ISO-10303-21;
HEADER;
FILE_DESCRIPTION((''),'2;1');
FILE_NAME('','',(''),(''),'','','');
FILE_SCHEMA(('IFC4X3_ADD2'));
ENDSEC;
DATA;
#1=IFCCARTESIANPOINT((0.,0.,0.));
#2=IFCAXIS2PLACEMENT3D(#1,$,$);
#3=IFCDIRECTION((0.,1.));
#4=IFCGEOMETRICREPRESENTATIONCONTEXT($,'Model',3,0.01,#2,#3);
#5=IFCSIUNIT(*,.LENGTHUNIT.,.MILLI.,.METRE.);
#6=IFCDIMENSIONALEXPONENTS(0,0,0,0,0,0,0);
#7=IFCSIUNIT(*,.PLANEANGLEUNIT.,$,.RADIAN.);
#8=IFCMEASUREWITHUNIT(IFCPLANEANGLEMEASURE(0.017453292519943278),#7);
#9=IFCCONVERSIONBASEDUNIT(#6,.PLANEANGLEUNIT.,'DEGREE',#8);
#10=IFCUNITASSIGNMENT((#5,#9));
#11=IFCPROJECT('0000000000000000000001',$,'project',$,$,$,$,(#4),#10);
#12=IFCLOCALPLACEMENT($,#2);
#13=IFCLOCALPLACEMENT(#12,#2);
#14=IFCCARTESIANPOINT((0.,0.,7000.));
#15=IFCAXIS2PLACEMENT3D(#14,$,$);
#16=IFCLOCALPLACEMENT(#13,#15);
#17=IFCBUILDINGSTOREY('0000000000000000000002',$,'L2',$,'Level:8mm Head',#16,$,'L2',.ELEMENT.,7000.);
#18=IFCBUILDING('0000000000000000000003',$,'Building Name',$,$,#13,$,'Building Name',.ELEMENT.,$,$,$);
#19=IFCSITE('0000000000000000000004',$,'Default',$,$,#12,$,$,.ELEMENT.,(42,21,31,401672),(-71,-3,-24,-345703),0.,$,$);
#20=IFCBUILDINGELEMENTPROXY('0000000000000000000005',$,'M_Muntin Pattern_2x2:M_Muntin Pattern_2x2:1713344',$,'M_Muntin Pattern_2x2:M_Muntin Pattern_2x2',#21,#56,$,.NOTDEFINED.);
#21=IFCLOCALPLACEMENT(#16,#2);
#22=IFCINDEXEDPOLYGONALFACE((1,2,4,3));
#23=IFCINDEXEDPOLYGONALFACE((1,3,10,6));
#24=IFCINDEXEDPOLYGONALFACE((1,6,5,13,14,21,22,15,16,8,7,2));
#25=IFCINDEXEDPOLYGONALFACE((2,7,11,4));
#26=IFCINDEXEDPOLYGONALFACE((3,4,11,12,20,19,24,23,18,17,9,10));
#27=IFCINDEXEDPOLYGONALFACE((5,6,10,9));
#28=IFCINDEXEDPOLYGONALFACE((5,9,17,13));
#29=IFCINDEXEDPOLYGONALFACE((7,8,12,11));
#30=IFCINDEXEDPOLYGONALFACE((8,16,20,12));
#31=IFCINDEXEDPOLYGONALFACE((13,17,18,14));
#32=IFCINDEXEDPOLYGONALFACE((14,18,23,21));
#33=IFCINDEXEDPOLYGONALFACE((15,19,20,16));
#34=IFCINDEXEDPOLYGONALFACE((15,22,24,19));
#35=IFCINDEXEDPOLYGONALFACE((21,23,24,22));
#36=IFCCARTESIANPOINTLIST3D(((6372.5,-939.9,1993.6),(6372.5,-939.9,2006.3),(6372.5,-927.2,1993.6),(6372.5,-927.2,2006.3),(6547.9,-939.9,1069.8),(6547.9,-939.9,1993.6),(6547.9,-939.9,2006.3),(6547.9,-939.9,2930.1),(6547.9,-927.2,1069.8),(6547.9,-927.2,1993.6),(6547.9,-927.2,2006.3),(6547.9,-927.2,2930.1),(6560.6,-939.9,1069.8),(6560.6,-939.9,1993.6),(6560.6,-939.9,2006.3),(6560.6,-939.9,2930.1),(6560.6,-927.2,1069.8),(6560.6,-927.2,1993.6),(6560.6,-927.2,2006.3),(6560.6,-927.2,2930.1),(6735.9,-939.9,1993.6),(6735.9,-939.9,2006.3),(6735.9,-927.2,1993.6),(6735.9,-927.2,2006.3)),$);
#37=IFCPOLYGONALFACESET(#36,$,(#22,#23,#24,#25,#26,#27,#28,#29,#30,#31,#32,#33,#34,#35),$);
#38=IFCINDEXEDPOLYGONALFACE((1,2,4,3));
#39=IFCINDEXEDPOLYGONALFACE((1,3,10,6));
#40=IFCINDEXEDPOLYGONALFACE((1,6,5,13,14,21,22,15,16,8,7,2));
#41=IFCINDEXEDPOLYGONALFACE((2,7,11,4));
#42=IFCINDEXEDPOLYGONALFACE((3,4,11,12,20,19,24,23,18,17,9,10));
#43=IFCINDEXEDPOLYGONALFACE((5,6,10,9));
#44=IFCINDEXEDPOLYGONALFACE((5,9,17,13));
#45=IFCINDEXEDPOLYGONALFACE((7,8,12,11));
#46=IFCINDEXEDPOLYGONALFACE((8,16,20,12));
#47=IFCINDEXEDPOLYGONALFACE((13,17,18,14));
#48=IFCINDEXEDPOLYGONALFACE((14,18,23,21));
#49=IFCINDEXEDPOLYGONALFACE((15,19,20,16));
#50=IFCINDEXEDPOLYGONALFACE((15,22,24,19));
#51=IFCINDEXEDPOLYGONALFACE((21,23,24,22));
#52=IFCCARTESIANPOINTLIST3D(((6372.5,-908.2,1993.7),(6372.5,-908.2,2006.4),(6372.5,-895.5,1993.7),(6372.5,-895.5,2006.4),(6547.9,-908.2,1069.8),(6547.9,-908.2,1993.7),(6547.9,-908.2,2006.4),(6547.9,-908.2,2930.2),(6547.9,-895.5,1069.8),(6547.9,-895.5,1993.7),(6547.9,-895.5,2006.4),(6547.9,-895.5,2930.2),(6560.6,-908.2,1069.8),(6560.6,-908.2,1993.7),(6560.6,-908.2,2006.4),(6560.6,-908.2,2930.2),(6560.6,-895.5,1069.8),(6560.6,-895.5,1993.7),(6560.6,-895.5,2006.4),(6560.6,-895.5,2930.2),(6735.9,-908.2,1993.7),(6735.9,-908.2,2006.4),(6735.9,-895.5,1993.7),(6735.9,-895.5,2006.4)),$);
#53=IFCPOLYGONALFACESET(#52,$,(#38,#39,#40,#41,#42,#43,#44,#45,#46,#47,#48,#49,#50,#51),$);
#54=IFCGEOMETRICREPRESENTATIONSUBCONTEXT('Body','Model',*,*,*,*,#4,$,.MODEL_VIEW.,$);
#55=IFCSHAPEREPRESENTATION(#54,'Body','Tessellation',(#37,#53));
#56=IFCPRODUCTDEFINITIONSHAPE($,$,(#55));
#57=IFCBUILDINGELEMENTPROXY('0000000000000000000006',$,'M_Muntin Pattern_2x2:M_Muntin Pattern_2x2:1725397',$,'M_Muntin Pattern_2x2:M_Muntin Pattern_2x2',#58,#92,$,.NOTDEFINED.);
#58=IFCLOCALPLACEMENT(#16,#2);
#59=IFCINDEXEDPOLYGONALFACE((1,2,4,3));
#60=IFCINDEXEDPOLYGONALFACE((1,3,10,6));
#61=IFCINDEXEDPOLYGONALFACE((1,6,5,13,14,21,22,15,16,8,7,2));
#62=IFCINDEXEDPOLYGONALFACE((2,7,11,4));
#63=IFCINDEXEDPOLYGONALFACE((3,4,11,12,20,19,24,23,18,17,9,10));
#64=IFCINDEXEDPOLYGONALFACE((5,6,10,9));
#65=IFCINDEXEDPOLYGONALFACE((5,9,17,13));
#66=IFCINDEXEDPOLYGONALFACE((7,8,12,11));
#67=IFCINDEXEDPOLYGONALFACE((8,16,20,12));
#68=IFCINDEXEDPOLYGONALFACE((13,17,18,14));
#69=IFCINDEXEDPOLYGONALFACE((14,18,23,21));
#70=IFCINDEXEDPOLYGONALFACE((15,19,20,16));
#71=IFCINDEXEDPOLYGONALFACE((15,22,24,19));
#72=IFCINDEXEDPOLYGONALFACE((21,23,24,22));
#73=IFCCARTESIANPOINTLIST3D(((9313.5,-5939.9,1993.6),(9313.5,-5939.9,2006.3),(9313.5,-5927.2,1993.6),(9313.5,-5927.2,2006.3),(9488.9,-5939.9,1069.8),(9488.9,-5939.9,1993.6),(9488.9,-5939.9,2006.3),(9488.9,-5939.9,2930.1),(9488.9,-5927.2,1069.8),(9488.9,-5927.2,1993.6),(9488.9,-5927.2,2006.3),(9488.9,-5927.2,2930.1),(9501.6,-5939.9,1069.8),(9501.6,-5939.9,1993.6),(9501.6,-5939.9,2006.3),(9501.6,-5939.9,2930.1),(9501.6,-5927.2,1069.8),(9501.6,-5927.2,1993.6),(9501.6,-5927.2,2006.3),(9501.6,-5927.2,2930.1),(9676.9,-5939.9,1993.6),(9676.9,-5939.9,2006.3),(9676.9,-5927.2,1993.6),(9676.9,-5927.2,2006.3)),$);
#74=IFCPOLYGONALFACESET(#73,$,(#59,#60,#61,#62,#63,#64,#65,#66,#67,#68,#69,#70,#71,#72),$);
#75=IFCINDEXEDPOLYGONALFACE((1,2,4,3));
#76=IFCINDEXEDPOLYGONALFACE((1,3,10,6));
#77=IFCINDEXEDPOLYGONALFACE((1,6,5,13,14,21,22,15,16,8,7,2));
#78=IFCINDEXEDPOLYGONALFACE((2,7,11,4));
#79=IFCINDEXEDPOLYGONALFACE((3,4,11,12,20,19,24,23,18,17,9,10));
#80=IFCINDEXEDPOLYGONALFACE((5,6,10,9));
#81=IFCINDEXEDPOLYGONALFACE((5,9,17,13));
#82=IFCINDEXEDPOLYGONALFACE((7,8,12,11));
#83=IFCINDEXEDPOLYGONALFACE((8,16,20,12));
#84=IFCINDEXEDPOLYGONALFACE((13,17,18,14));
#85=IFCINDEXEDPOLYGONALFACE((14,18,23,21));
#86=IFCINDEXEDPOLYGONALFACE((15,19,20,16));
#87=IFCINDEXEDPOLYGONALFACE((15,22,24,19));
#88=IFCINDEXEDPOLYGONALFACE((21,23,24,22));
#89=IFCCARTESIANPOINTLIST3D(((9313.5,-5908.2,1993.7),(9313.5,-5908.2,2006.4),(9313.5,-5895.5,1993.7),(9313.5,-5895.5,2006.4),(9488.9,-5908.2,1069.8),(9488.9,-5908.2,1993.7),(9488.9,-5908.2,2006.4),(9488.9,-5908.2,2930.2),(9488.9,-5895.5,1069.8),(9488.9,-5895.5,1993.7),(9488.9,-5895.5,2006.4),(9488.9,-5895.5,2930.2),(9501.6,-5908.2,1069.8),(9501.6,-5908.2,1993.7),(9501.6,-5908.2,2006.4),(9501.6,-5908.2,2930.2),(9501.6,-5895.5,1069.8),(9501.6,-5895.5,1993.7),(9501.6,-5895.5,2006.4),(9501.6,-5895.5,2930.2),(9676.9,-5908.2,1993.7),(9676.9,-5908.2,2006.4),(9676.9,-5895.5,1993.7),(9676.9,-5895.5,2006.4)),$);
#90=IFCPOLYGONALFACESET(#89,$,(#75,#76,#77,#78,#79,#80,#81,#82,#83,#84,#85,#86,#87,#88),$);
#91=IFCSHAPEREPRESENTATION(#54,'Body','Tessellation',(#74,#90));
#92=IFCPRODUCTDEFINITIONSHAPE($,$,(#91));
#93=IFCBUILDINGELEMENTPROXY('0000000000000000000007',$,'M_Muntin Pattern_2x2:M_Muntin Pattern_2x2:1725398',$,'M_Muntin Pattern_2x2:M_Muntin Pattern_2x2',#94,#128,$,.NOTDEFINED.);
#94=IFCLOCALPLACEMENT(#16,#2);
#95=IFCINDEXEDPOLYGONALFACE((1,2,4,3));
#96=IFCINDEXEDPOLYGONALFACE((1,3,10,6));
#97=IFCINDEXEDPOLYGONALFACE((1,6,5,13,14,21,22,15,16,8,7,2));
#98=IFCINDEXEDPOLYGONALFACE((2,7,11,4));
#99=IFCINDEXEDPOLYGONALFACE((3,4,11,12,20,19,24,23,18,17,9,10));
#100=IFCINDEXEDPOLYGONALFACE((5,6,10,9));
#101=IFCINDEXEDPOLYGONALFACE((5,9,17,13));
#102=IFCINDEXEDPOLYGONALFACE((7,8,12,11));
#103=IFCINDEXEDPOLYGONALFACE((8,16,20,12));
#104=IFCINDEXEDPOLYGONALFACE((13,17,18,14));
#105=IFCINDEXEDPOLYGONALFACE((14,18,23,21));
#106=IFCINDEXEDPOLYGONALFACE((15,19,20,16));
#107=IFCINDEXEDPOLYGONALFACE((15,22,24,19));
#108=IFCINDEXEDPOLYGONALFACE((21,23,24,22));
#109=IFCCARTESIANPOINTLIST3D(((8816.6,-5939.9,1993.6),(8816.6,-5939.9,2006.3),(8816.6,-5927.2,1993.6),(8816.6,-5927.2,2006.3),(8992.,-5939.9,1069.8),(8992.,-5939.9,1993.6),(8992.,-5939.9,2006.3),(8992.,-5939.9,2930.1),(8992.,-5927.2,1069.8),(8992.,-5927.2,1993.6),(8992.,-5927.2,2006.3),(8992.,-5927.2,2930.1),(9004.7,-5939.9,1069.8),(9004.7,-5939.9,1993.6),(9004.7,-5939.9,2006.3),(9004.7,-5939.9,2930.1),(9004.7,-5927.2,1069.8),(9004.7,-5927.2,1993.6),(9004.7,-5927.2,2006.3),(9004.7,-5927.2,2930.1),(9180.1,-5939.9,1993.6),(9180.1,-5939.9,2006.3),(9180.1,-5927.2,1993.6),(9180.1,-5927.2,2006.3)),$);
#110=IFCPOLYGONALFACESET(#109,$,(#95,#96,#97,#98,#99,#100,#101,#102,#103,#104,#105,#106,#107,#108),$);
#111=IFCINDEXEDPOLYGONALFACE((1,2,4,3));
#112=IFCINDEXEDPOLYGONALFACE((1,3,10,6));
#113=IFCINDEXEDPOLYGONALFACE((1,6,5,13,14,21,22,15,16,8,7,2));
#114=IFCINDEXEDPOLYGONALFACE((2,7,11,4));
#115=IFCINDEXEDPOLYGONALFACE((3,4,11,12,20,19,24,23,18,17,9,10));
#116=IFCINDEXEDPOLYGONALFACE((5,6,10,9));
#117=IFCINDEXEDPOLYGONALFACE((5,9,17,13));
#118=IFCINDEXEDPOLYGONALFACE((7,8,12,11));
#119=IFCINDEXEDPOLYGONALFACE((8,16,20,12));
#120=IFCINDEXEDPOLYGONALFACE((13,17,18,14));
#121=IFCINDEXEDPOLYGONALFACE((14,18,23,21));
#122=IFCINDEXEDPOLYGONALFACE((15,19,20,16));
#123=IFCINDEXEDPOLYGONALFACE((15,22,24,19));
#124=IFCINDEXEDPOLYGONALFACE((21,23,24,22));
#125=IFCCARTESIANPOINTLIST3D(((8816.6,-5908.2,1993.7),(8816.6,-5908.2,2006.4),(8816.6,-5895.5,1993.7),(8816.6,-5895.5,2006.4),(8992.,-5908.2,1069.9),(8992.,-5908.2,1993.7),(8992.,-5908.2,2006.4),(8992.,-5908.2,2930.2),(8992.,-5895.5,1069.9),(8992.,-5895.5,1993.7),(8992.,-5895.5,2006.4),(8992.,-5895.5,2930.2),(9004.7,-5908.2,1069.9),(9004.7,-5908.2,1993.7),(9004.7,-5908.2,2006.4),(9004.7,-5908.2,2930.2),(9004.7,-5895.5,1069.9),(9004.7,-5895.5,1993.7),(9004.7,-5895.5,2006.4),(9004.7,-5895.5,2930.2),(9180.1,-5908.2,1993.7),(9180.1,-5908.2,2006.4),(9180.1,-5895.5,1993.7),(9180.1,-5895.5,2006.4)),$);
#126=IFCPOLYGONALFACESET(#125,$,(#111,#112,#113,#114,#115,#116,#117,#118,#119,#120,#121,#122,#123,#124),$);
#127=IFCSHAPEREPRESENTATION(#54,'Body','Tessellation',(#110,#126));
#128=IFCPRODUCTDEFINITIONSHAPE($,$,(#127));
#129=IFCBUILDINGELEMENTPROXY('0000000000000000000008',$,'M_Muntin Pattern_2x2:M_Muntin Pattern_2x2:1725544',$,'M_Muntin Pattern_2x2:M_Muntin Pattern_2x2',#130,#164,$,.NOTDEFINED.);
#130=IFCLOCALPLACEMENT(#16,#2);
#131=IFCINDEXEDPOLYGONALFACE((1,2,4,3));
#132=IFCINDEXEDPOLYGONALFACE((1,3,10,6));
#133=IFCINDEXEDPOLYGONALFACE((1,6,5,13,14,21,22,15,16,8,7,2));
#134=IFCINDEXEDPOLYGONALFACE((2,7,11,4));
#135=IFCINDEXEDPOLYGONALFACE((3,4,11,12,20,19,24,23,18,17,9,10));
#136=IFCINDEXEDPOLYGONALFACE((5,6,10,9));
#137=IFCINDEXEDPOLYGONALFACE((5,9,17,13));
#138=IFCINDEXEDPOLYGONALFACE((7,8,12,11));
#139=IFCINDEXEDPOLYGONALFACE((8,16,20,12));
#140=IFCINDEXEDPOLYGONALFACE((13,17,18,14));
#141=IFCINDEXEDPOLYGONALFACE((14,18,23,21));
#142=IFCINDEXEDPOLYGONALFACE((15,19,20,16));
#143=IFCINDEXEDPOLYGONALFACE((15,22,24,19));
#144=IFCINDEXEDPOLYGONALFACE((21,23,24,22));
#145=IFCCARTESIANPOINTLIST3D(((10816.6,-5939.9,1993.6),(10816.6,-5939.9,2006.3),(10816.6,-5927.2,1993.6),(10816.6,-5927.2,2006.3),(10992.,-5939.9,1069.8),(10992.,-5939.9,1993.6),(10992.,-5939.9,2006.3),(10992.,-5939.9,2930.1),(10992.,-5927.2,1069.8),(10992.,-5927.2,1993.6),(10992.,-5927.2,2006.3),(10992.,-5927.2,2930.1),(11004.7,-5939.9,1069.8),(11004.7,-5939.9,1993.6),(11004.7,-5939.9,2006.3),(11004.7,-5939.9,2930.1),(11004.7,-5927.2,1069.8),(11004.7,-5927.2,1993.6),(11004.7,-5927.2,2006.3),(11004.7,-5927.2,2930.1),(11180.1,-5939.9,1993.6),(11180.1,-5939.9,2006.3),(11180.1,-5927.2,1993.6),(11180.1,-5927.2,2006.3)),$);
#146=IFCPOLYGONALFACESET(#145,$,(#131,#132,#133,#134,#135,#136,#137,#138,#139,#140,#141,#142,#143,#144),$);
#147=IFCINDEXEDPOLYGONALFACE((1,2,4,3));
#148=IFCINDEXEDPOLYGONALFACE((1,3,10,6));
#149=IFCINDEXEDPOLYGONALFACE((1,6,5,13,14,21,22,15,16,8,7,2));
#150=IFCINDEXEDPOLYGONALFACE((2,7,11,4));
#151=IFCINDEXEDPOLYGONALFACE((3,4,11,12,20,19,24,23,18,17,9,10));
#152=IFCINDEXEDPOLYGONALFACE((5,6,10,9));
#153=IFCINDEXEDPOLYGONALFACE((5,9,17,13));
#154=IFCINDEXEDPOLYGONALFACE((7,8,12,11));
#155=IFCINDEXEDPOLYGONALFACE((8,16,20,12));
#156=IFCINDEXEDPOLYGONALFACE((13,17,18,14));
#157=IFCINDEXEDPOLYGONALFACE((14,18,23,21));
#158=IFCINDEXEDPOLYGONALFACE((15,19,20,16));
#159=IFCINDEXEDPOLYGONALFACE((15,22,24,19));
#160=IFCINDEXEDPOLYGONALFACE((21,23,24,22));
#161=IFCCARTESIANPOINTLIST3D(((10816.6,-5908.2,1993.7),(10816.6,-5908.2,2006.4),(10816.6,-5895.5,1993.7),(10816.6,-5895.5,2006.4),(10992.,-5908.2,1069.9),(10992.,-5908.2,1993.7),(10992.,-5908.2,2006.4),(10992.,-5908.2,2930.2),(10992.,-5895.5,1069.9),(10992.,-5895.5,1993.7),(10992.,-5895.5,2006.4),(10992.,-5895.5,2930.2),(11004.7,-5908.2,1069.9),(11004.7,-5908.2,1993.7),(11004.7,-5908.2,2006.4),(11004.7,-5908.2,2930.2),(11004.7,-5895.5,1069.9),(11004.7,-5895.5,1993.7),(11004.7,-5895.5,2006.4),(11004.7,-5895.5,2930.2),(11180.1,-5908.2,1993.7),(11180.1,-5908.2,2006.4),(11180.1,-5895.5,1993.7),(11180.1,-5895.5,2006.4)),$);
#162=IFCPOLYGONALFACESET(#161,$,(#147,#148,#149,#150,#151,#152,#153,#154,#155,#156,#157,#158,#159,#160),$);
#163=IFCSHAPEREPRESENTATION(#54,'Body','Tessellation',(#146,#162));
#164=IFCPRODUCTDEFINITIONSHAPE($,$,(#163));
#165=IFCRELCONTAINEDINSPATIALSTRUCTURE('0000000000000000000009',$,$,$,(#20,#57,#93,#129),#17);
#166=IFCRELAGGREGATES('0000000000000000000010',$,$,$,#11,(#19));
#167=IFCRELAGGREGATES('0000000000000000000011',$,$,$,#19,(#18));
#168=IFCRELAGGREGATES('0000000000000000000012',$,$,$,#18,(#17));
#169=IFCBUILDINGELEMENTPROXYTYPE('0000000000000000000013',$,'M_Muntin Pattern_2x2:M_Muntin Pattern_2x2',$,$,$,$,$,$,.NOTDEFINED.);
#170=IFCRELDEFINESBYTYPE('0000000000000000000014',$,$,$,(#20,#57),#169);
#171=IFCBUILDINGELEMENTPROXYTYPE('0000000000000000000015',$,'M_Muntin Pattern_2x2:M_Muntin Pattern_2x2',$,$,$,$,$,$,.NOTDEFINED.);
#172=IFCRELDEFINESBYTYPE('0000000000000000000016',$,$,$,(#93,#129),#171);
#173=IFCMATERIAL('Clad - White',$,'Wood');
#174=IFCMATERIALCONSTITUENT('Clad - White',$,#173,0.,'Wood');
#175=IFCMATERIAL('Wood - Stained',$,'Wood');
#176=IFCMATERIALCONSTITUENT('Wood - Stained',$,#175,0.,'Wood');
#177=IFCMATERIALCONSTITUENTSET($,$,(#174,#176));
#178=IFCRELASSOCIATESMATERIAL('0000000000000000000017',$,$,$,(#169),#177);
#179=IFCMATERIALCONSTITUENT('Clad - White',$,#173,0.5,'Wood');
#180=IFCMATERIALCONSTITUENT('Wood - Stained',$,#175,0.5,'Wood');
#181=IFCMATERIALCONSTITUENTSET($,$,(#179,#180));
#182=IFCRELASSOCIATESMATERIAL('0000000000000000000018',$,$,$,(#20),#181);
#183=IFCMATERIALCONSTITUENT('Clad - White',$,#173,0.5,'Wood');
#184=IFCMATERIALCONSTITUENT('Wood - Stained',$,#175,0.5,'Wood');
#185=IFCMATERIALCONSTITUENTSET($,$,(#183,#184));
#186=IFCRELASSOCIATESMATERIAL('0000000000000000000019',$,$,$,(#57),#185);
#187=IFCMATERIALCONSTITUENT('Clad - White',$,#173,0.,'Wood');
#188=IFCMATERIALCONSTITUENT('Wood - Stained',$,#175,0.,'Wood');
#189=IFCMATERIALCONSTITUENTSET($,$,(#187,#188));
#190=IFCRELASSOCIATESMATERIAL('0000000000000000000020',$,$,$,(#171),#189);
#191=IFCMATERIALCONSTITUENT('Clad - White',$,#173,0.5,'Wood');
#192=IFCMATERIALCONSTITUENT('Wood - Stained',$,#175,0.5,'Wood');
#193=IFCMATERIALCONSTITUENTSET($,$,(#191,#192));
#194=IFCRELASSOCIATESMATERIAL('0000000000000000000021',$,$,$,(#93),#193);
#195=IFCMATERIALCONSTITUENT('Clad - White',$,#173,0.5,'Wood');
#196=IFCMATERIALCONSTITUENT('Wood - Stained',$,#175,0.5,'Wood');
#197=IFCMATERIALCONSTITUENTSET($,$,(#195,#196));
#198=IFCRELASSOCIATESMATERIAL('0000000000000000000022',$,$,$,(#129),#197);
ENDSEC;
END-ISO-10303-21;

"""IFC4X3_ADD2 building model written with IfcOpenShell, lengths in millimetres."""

from ifc_helpers import new_model, entity, si_unit, converted_unit, direction, frame, origin, place, context, subcontext, project, spatial, polyline, outline, extrude, source, transform, mapped, material, constituent, constituent_set, type_object, type_shapes, element, save


model = new_model("IFC4X3_ADD2")

# Units and contexts
model_context = context("Model", 3, precision=0.01, world=origin(), true_north=direction((0.0, 1.0)))
body_context = subcontext(model_context, "Body", "Model", "MODEL_VIEW")
ifc_project = project(units=[si_unit("LENGTHUNIT", "METRE", prefix="MILLI"), converted_unit("PLANEANGLEUNIT", "DEGREE", entity("IfcPlaneAngleMeasure", 0.017453292519943278), si_unit("PLANEANGLEUNIT", "RADIAN"), dimensions=[0, 0, 0, 0, 0, 0, 0])], contexts=[model_context])

# Site, building, storey
site_placement = place(None, origin())
site = spatial("IfcSite", under=ifc_project, at=site_placement, Name="Default", CompositionType="ELEMENT", RefLatitude=(42, 21, 31, 401672), RefLongitude=(-71, -3, -24, -345703), RefElevation=0.0)
building_placement = place(site_placement, origin())
building = spatial("IfcBuilding", under=site, at=building_placement, Name="Building Name", LongName="Building Name", CompositionType="ELEMENT")
storey_placement = place(building_placement, frame((0.0, 0.0, 7000.0)))
storey = spatial("IfcBuildingStorey", under=building, at=storey_placement, Name="L2", ObjectType="Level:8mm Head", LongName="L2", CompositionType="ELEMENT", Elevation=7000.0)

# Shared definitions
ifc_material_1 = material(Name="Clad - White", Category="Wood")
ifc_material_2 = material(Name="Wood - Stained", Category="Wood")

# Building element proxies
ifc_constituent_1 = constituent(ifc_material_1, Name="Clad - White", Category="Wood", fraction=0.5)
ifc_constituent_2 = constituent(ifc_material_2, Name="Wood - Stained", Category="Wood", fraction=0.5)
ifc_constituent_set_1 = constituent_set(constituents=[ifc_constituent_1, ifc_constituent_2])
ifc_constituent_3 = constituent(ifc_material_1, Name="Clad - White", Category="Wood", fraction=0.0)
ifc_constituent_4 = constituent(ifc_material_2, Name="Wood - Stained", Category="Wood", fraction=0.0)
ifc_constituent_set_2 = constituent_set(constituents=[ifc_constituent_3, ifc_constituent_4])
building_element_proxy_type_1 = type_object("IfcBuildingElementProxyType", Name="M_Muntin Pattern_2x2:M_Muntin Pattern_2x2", PredefinedType="NOTDEFINED", material=ifc_constituent_set_2)
shared_shape_1 = source(origin(), body_context, "Body", "SweptSolid", [
    extrude(outline(polyline([(6.4, -6.4), (930.1, -6.4), (930.1, 6.3), (6.4, 6.3), (6.4, 181.7), (-6.3, 181.7), (-6.3, 6.3), (-930.2, 6.3), (-930.2, -6.4), (-6.3, -6.4), (-6.3, -181.7), (6.4, -181.7), (6.4, -6.4)])), frame((0.0, 9.5, 930.1), z_axis=(0.0, 1.0, 0.0), x_axis=(0.0, 0.0, 1.0)), (0.0, 0.0, 1.0), 12.7),
    extrude(outline(polyline([(6.4, -6.4), (930.2, -6.4), (930.2, 6.3), (6.4, 6.3), (6.4, 181.7), (-6.3, 181.7), (-6.3, 6.3), (-930.2, 6.3), (-930.2, -6.4), (-6.3, -6.4), (-6.3, -181.7), (6.4, -181.7), (6.4, -6.4)])), frame((0.0, -22.2, 930.2), z_axis=(0.0, 1.0, 0.0), x_axis=(0.0, 0.0, 1.0)), (0.0, 0.0, 1.0), 12.7),
])
type_shapes(building_element_proxy_type_1, [shared_shape_1])
proxy_1_placement = place(storey_placement, frame((6554.2, -917.7, 1069.8), z_axis=(0.0, 0.0, 1.0), x_axis=(-1.0, 0.0, 0.0)))
element("IfcBuildingElementProxy", 1, at=proxy_1_placement, inside=storey, type_object=building_element_proxy_type_1, material=ifc_constituent_set_1, Name="M_Muntin Pattern_2x2:M_Muntin Pattern_2x2:1713344", ObjectType="M_Muntin Pattern_2x2:M_Muntin Pattern_2x2", PredefinedType="NOTDEFINED", context=body_context, shape_type="MappedRepresentation", body=[
    mapped(shared_shape_1, transform((0.0, 0.0, 0.0), scale=1.0)),
])
ifc_constituent_5 = constituent(ifc_material_1, Name="Clad - White", Category="Wood", fraction=0.5)
ifc_constituent_6 = constituent(ifc_material_2, Name="Wood - Stained", Category="Wood", fraction=0.5)
ifc_constituent_set_3 = constituent_set(constituents=[ifc_constituent_5, ifc_constituent_6])
proxy_2_placement = place(storey_placement, frame((9495.2, -5917.7, 1069.8), z_axis=(0.0, 0.0, 1.0), x_axis=(-1.0, 0.0, 0.0)))
element("IfcBuildingElementProxy", 2, at=proxy_2_placement, inside=storey, type_object=building_element_proxy_type_1, material=ifc_constituent_set_3, Name="M_Muntin Pattern_2x2:M_Muntin Pattern_2x2:1725397", ObjectType="M_Muntin Pattern_2x2:M_Muntin Pattern_2x2", PredefinedType="NOTDEFINED", context=body_context, shape_type="MappedRepresentation", body=[
    mapped(shared_shape_1, transform((0.0, 0.0, 0.0), scale=1.0)),
])
ifc_constituent_7 = constituent(ifc_material_1, Name="Clad - White", Category="Wood", fraction=0.5)
ifc_constituent_8 = constituent(ifc_material_2, Name="Wood - Stained", Category="Wood", fraction=0.5)
ifc_constituent_set_4 = constituent_set(constituents=[ifc_constituent_7, ifc_constituent_8])
ifc_constituent_9 = constituent(ifc_material_1, Name="Clad - White", Category="Wood", fraction=0.0)
ifc_constituent_10 = constituent(ifc_material_2, Name="Wood - Stained", Category="Wood", fraction=0.0)
ifc_constituent_set_5 = constituent_set(constituents=[ifc_constituent_9, ifc_constituent_10])
building_element_proxy_type_2 = type_object("IfcBuildingElementProxyType", Name="M_Muntin Pattern_2x2:M_Muntin Pattern_2x2", PredefinedType="NOTDEFINED", material=ifc_constituent_set_5)
shared_shape_2 = source(origin(), body_context, "Body", "SweptSolid", [
    extrude(outline(polyline([(6.4, -6.4), (930.1, -6.4), (930.1, 6.3), (6.4, 6.3), (6.4, 181.7), (-6.3, 181.7), (-6.3, 6.3), (-930.2, 6.3), (-930.2, -6.4), (-6.3, -6.4), (-6.3, -181.7), (6.4, -181.7), (6.4, -6.4)])), frame((0.0, -22.2, 930.1), z_axis=(0.0, 1.0, 0.0), x_axis=(0.0, 0.0, 1.0)), (0.0, 0.0, 1.0), 12.7),
    extrude(outline(polyline([(6.4, -6.4), (930.2, -6.4), (930.2, 6.3), (6.4, 6.3), (6.4, 181.7), (-6.3, 181.7), (-6.3, 6.3), (-930.2, 6.3), (-930.2, -6.4), (-6.3, -6.4), (-6.3, -181.7), (6.4, -181.7), (6.4, -6.4)])), frame((0.0, 9.5, 930.2), z_axis=(0.0, 1.0, 0.0), x_axis=(0.0, 0.0, 1.0)), (0.0, 0.0, 1.0), 12.7),
])
type_shapes(building_element_proxy_type_2, [shared_shape_2])
proxy_3_placement = place(storey_placement, frame((8998.4, -5917.7, 1069.9)))
element("IfcBuildingElementProxy", 3, at=proxy_3_placement, inside=storey, type_object=building_element_proxy_type_2, material=ifc_constituent_set_4, Name="M_Muntin Pattern_2x2:M_Muntin Pattern_2x2:1725398", ObjectType="M_Muntin Pattern_2x2:M_Muntin Pattern_2x2", PredefinedType="NOTDEFINED", context=body_context, shape_type="MappedRepresentation", body=[
    mapped(shared_shape_2, transform((0.0, 0.0, 0.0), scale=1.0)),
])
ifc_constituent_11 = constituent(ifc_material_1, Name="Clad - White", Category="Wood", fraction=0.5)
ifc_constituent_12 = constituent(ifc_material_2, Name="Wood - Stained", Category="Wood", fraction=0.5)
ifc_constituent_set_6 = constituent_set(constituents=[ifc_constituent_11, ifc_constituent_12])
proxy_4_placement = place(storey_placement, frame((10998.4, -5917.7, 1069.9)))
element("IfcBuildingElementProxy", 4, at=proxy_4_placement, inside=storey, type_object=building_element_proxy_type_2, material=ifc_constituent_set_6, Name="M_Muntin Pattern_2x2:M_Muntin Pattern_2x2:1725544", ObjectType="M_Muntin Pattern_2x2:M_Muntin Pattern_2x2", PredefinedType="NOTDEFINED", context=body_context, shape_type="MappedRepresentation", body=[
    mapped(shared_shape_2, transform((0.0, 0.0, 0.0), scale=1.0)),
])

save(model, "model.ifc")
